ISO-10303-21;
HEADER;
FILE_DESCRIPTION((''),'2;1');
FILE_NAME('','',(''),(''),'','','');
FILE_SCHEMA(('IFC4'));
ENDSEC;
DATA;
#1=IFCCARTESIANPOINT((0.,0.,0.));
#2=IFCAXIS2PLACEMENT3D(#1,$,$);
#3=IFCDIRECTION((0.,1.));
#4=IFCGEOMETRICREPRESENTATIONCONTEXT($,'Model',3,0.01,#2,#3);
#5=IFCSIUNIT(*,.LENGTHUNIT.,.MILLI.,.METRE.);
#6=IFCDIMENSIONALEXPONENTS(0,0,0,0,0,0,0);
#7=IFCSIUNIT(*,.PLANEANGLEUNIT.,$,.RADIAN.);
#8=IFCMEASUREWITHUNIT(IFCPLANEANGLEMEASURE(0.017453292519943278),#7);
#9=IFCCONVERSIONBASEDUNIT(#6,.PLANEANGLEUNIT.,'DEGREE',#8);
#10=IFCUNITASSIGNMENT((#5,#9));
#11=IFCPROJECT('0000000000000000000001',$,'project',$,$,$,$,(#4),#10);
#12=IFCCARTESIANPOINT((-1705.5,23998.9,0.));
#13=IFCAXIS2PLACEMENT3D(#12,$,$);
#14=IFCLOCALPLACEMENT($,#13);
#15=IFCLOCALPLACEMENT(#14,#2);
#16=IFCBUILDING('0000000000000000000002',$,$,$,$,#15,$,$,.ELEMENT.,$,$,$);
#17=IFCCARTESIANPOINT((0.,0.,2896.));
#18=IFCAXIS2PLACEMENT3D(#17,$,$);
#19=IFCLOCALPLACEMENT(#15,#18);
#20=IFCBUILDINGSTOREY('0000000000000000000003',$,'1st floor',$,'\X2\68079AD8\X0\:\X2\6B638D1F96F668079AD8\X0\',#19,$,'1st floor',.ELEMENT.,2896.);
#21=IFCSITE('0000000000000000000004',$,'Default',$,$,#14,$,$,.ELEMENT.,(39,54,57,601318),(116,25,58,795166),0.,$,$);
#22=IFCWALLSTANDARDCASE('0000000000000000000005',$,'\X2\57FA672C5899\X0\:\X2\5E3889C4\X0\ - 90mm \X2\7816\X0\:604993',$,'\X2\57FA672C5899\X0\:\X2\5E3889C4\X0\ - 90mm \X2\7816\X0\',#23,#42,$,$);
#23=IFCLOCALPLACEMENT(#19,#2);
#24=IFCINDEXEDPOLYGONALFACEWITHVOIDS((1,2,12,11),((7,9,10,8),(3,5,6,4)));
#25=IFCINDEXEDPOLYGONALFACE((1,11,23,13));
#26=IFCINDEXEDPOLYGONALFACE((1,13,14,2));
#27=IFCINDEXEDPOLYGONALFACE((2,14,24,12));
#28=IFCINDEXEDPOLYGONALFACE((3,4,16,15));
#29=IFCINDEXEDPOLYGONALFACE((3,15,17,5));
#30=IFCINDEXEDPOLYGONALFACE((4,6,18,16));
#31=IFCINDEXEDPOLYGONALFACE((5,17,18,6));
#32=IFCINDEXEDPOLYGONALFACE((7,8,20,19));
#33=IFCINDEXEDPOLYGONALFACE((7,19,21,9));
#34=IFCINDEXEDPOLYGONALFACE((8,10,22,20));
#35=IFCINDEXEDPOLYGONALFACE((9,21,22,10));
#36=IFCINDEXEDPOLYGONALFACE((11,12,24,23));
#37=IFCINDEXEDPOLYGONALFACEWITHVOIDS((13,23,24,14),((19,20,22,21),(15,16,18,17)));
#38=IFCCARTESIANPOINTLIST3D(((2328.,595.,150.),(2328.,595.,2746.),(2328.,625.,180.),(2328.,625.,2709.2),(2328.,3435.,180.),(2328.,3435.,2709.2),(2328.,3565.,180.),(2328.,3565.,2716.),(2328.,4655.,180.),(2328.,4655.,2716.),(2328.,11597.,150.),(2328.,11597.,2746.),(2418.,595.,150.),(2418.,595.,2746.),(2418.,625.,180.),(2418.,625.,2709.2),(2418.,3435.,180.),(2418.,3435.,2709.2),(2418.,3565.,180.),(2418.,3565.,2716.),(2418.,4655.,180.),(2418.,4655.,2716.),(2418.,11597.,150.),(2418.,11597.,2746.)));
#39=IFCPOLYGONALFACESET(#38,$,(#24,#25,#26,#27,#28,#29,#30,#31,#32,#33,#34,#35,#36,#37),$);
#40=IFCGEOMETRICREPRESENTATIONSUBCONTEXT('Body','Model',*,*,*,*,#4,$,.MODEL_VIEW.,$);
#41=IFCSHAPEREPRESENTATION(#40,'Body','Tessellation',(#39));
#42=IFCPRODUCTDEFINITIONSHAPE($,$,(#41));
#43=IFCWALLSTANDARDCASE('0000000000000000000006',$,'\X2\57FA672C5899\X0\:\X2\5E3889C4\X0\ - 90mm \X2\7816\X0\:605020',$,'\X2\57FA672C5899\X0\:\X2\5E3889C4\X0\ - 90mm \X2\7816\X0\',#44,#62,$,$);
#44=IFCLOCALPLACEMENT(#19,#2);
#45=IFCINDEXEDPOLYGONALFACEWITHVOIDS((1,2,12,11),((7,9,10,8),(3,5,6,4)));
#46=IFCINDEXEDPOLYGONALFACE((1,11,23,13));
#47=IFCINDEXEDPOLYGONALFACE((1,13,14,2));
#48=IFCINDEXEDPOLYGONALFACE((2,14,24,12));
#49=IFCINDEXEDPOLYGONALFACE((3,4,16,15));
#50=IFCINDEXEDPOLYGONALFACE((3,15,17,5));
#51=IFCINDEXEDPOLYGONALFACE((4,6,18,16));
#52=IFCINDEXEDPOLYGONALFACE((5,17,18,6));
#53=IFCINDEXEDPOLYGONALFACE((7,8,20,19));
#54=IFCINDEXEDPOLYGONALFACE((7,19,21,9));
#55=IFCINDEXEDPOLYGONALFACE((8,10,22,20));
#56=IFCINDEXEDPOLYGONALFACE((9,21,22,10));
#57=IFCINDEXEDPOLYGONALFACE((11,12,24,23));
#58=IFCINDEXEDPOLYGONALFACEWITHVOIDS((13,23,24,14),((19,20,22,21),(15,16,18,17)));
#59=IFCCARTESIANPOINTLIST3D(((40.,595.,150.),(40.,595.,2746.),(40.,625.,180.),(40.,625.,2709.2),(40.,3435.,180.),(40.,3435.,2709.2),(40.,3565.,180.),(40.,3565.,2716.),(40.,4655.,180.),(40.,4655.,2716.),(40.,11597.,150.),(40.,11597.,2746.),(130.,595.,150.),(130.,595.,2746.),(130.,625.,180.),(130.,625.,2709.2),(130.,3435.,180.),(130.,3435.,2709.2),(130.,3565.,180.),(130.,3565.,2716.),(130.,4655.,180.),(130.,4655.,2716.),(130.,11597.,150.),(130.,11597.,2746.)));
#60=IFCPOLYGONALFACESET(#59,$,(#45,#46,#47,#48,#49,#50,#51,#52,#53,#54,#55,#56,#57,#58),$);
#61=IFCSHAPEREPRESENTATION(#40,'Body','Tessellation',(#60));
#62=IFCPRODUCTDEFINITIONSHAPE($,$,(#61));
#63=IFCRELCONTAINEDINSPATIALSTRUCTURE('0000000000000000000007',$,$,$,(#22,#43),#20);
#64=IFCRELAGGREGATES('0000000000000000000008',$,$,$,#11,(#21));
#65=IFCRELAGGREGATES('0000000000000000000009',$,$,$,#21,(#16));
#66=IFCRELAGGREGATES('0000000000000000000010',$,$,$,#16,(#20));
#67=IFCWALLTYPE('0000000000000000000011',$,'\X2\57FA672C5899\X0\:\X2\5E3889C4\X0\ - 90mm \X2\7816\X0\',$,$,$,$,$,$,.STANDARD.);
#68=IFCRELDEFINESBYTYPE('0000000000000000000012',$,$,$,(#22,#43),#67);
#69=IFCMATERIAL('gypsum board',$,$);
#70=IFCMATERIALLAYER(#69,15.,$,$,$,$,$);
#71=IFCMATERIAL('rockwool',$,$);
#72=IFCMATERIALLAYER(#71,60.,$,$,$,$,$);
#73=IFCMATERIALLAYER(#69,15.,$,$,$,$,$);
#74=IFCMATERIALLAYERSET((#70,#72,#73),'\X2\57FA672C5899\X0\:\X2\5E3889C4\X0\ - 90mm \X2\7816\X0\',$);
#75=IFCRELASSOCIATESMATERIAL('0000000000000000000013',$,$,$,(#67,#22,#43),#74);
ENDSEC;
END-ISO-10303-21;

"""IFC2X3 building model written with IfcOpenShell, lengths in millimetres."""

from ifc_helpers import new_model, entity, si_unit, converted_unit, direction, frame, frame_2d, origin, place, context, subcontext, project, spatial, rectangle, extrude, material, layer, layer_set, layer_usage, type_object, element, save


model = new_model("IFC2X3")

# Units and contexts
model_context = context("Model", 3, precision=0.01, world=origin(), true_north=direction((0.0, 1.0)))
body_context = subcontext(model_context, "Body", "Model", "MODEL_VIEW")
ifc_project = project(units=[si_unit("LENGTHUNIT", "METRE", prefix="MILLI"), converted_unit("PLANEANGLEUNIT", "DEGREE", entity("IfcPlaneAngleMeasure", 0.017453292519943278), si_unit("PLANEANGLEUNIT", "RADIAN"), dimensions=[0, 0, 0, 0, 0, 0, 0])], contexts=[model_context])

# Site, building, storey
site_placement = place(None, frame((-1705.5, 23998.9, 0.0)))
site = spatial("IfcSite", under=ifc_project, at=site_placement, Name="Default", CompositionType="ELEMENT", RefLatitude=(39, 54, 57, 601318), RefLongitude=(116, 25, 58, 795166), RefElevation=0.0)
building_placement = place(site_placement, origin())
building = spatial("IfcBuilding", under=site, at=building_placement, CompositionType="ELEMENT")
storey_placement = place(building_placement, frame((0.0, 0.0, 2896.0)))
storey = spatial("IfcBuildingStorey", under=building, at=storey_placement, Name="1st floor", ObjectType="标高:正负零标高", LongName="1st floor", CompositionType="ELEMENT", Elevation=2896.0)

# Shared definitions
ifc_material_1 = material(Name="gypsum board")
ifc_layer_1 = layer(ifc_material_1, 15.0)
ifc_material_2 = material(Name="rockwool")
ifc_layer_2 = layer(ifc_material_2, 60.0)
ifc_layer_3 = layer(ifc_material_1, 15.0)
ifc_layer_set = layer_set([ifc_layer_1, ifc_layer_2, ifc_layer_3], Name="基本墙:常规 - 90mm 砖")
wall_type = type_object("IfcWallType", Name="基本墙:常规 - 90mm 砖", PredefinedType="STANDARD", material=ifc_layer_set)

# Walls, openings
ifc_layer_usage_1 = layer_usage(ifc_layer_set, "AXIS2", "NEGATIVE", 45.0)
wall_1_placement = place(storey_placement, frame((2373.0, 11597.0, 150.0), z_axis=(0.0, 0.0, 1.0), x_axis=(0.0, -1.0, 0.0)))
wall_1 = element("IfcWallStandardCase", 1, at=wall_1_placement, inside=storey, type_object=wall_type, material=ifc_layer_usage_1, Name="基本墙:常规 - 90mm 砖:604993", ObjectType="基本墙:常规 - 90mm 砖", context=body_context, shape_type="SweptSolid", body=[
    extrude(rectangle(XDim=11002.0, YDim=90.0, at=frame_2d((5501.0, 0.0), x_axis=(-1.0, 0.0))), origin(), (0.0, 0.0, 1.0), 2596.0),
])
opening_1_placement = place(wall_1_placement, origin())
element("IfcOpeningElement", 2, at=opening_1_placement, cuts=wall_1, ObjectType="Opening", context=body_context, shape_type="SweptSolid", body=[
    extrude(rectangle(XDim=2536.0, YDim=1090.0, at=frame_2d((0.0, 0.0), x_axis=(0.0, 1.0))), frame((7487.0, 45.0, 1298.0), z_axis=(0.0, -1.0, 0.0), x_axis=(-1.0, 0.0, 0.0)), (0.0, 0.0, 1.0), 90.0),
])
opening_2_placement = place(wall_1_placement, origin())
element("IfcOpeningElement", 3, at=opening_2_placement, cuts=wall_1, ObjectType="Opening", context=body_context, shape_type="SweptSolid", body=[
    extrude(rectangle(XDim=2529.2, YDim=2810.0, at=frame_2d((0.0, 0.0), x_axis=(0.0, 1.0))), frame((9567.0, 45.0, 1294.6), z_axis=(0.0, -1.0, 0.0), x_axis=(-1.0, 0.0, 0.0)), (0.0, 0.0, 1.0), 90.0),
])
ifc_layer_usage_2 = layer_usage(ifc_layer_set, "AXIS2", "NEGATIVE", 45.0)
wall_2_placement = place(storey_placement, frame((85.0, 11597.0, 150.0), z_axis=(0.0, 0.0, 1.0), x_axis=(0.0, -1.0, 0.0)))
wall_2 = element("IfcWallStandardCase", 4, at=wall_2_placement, inside=storey, type_object=wall_type, material=ifc_layer_usage_2, Name="基本墙:常规 - 90mm 砖:605020", ObjectType="基本墙:常规 - 90mm 砖", context=body_context, shape_type="SweptSolid", body=[
    extrude(rectangle(XDim=11002.0, YDim=90.0, at=frame_2d((5501.0, 0.0), x_axis=(-1.0, 0.0))), origin(), (0.0, 0.0, 1.0), 2596.0),
])
opening_3_placement = place(wall_2_placement, origin())
element("IfcOpeningElement", 5, at=opening_3_placement, cuts=wall_2, ObjectType="Opening", context=body_context, shape_type="SweptSolid", body=[
    extrude(rectangle(XDim=2536.0, YDim=1090.0, at=frame_2d((0.0, 0.0), x_axis=(0.0, 1.0))), frame((7487.0, 45.0, 1298.0), z_axis=(0.0, -1.0, 0.0), x_axis=(-1.0, 0.0, 0.0)), (0.0, 0.0, 1.0), 90.0),
])
opening_4_placement = place(wall_2_placement, origin())
element("IfcOpeningElement", 6, at=opening_4_placement, cuts=wall_2, ObjectType="Opening", context=body_context, shape_type="SweptSolid", body=[
    extrude(rectangle(XDim=2529.2, YDim=2810.0, at=frame_2d((0.0, 0.0), x_axis=(0.0, 1.0))), frame((9567.0, 45.0, 1294.6), z_axis=(0.0, -1.0, 0.0), x_axis=(-1.0, 0.0, 0.0)), (0.0, 0.0, 1.0), 90.0),
])

save(model, "model.ifc")
